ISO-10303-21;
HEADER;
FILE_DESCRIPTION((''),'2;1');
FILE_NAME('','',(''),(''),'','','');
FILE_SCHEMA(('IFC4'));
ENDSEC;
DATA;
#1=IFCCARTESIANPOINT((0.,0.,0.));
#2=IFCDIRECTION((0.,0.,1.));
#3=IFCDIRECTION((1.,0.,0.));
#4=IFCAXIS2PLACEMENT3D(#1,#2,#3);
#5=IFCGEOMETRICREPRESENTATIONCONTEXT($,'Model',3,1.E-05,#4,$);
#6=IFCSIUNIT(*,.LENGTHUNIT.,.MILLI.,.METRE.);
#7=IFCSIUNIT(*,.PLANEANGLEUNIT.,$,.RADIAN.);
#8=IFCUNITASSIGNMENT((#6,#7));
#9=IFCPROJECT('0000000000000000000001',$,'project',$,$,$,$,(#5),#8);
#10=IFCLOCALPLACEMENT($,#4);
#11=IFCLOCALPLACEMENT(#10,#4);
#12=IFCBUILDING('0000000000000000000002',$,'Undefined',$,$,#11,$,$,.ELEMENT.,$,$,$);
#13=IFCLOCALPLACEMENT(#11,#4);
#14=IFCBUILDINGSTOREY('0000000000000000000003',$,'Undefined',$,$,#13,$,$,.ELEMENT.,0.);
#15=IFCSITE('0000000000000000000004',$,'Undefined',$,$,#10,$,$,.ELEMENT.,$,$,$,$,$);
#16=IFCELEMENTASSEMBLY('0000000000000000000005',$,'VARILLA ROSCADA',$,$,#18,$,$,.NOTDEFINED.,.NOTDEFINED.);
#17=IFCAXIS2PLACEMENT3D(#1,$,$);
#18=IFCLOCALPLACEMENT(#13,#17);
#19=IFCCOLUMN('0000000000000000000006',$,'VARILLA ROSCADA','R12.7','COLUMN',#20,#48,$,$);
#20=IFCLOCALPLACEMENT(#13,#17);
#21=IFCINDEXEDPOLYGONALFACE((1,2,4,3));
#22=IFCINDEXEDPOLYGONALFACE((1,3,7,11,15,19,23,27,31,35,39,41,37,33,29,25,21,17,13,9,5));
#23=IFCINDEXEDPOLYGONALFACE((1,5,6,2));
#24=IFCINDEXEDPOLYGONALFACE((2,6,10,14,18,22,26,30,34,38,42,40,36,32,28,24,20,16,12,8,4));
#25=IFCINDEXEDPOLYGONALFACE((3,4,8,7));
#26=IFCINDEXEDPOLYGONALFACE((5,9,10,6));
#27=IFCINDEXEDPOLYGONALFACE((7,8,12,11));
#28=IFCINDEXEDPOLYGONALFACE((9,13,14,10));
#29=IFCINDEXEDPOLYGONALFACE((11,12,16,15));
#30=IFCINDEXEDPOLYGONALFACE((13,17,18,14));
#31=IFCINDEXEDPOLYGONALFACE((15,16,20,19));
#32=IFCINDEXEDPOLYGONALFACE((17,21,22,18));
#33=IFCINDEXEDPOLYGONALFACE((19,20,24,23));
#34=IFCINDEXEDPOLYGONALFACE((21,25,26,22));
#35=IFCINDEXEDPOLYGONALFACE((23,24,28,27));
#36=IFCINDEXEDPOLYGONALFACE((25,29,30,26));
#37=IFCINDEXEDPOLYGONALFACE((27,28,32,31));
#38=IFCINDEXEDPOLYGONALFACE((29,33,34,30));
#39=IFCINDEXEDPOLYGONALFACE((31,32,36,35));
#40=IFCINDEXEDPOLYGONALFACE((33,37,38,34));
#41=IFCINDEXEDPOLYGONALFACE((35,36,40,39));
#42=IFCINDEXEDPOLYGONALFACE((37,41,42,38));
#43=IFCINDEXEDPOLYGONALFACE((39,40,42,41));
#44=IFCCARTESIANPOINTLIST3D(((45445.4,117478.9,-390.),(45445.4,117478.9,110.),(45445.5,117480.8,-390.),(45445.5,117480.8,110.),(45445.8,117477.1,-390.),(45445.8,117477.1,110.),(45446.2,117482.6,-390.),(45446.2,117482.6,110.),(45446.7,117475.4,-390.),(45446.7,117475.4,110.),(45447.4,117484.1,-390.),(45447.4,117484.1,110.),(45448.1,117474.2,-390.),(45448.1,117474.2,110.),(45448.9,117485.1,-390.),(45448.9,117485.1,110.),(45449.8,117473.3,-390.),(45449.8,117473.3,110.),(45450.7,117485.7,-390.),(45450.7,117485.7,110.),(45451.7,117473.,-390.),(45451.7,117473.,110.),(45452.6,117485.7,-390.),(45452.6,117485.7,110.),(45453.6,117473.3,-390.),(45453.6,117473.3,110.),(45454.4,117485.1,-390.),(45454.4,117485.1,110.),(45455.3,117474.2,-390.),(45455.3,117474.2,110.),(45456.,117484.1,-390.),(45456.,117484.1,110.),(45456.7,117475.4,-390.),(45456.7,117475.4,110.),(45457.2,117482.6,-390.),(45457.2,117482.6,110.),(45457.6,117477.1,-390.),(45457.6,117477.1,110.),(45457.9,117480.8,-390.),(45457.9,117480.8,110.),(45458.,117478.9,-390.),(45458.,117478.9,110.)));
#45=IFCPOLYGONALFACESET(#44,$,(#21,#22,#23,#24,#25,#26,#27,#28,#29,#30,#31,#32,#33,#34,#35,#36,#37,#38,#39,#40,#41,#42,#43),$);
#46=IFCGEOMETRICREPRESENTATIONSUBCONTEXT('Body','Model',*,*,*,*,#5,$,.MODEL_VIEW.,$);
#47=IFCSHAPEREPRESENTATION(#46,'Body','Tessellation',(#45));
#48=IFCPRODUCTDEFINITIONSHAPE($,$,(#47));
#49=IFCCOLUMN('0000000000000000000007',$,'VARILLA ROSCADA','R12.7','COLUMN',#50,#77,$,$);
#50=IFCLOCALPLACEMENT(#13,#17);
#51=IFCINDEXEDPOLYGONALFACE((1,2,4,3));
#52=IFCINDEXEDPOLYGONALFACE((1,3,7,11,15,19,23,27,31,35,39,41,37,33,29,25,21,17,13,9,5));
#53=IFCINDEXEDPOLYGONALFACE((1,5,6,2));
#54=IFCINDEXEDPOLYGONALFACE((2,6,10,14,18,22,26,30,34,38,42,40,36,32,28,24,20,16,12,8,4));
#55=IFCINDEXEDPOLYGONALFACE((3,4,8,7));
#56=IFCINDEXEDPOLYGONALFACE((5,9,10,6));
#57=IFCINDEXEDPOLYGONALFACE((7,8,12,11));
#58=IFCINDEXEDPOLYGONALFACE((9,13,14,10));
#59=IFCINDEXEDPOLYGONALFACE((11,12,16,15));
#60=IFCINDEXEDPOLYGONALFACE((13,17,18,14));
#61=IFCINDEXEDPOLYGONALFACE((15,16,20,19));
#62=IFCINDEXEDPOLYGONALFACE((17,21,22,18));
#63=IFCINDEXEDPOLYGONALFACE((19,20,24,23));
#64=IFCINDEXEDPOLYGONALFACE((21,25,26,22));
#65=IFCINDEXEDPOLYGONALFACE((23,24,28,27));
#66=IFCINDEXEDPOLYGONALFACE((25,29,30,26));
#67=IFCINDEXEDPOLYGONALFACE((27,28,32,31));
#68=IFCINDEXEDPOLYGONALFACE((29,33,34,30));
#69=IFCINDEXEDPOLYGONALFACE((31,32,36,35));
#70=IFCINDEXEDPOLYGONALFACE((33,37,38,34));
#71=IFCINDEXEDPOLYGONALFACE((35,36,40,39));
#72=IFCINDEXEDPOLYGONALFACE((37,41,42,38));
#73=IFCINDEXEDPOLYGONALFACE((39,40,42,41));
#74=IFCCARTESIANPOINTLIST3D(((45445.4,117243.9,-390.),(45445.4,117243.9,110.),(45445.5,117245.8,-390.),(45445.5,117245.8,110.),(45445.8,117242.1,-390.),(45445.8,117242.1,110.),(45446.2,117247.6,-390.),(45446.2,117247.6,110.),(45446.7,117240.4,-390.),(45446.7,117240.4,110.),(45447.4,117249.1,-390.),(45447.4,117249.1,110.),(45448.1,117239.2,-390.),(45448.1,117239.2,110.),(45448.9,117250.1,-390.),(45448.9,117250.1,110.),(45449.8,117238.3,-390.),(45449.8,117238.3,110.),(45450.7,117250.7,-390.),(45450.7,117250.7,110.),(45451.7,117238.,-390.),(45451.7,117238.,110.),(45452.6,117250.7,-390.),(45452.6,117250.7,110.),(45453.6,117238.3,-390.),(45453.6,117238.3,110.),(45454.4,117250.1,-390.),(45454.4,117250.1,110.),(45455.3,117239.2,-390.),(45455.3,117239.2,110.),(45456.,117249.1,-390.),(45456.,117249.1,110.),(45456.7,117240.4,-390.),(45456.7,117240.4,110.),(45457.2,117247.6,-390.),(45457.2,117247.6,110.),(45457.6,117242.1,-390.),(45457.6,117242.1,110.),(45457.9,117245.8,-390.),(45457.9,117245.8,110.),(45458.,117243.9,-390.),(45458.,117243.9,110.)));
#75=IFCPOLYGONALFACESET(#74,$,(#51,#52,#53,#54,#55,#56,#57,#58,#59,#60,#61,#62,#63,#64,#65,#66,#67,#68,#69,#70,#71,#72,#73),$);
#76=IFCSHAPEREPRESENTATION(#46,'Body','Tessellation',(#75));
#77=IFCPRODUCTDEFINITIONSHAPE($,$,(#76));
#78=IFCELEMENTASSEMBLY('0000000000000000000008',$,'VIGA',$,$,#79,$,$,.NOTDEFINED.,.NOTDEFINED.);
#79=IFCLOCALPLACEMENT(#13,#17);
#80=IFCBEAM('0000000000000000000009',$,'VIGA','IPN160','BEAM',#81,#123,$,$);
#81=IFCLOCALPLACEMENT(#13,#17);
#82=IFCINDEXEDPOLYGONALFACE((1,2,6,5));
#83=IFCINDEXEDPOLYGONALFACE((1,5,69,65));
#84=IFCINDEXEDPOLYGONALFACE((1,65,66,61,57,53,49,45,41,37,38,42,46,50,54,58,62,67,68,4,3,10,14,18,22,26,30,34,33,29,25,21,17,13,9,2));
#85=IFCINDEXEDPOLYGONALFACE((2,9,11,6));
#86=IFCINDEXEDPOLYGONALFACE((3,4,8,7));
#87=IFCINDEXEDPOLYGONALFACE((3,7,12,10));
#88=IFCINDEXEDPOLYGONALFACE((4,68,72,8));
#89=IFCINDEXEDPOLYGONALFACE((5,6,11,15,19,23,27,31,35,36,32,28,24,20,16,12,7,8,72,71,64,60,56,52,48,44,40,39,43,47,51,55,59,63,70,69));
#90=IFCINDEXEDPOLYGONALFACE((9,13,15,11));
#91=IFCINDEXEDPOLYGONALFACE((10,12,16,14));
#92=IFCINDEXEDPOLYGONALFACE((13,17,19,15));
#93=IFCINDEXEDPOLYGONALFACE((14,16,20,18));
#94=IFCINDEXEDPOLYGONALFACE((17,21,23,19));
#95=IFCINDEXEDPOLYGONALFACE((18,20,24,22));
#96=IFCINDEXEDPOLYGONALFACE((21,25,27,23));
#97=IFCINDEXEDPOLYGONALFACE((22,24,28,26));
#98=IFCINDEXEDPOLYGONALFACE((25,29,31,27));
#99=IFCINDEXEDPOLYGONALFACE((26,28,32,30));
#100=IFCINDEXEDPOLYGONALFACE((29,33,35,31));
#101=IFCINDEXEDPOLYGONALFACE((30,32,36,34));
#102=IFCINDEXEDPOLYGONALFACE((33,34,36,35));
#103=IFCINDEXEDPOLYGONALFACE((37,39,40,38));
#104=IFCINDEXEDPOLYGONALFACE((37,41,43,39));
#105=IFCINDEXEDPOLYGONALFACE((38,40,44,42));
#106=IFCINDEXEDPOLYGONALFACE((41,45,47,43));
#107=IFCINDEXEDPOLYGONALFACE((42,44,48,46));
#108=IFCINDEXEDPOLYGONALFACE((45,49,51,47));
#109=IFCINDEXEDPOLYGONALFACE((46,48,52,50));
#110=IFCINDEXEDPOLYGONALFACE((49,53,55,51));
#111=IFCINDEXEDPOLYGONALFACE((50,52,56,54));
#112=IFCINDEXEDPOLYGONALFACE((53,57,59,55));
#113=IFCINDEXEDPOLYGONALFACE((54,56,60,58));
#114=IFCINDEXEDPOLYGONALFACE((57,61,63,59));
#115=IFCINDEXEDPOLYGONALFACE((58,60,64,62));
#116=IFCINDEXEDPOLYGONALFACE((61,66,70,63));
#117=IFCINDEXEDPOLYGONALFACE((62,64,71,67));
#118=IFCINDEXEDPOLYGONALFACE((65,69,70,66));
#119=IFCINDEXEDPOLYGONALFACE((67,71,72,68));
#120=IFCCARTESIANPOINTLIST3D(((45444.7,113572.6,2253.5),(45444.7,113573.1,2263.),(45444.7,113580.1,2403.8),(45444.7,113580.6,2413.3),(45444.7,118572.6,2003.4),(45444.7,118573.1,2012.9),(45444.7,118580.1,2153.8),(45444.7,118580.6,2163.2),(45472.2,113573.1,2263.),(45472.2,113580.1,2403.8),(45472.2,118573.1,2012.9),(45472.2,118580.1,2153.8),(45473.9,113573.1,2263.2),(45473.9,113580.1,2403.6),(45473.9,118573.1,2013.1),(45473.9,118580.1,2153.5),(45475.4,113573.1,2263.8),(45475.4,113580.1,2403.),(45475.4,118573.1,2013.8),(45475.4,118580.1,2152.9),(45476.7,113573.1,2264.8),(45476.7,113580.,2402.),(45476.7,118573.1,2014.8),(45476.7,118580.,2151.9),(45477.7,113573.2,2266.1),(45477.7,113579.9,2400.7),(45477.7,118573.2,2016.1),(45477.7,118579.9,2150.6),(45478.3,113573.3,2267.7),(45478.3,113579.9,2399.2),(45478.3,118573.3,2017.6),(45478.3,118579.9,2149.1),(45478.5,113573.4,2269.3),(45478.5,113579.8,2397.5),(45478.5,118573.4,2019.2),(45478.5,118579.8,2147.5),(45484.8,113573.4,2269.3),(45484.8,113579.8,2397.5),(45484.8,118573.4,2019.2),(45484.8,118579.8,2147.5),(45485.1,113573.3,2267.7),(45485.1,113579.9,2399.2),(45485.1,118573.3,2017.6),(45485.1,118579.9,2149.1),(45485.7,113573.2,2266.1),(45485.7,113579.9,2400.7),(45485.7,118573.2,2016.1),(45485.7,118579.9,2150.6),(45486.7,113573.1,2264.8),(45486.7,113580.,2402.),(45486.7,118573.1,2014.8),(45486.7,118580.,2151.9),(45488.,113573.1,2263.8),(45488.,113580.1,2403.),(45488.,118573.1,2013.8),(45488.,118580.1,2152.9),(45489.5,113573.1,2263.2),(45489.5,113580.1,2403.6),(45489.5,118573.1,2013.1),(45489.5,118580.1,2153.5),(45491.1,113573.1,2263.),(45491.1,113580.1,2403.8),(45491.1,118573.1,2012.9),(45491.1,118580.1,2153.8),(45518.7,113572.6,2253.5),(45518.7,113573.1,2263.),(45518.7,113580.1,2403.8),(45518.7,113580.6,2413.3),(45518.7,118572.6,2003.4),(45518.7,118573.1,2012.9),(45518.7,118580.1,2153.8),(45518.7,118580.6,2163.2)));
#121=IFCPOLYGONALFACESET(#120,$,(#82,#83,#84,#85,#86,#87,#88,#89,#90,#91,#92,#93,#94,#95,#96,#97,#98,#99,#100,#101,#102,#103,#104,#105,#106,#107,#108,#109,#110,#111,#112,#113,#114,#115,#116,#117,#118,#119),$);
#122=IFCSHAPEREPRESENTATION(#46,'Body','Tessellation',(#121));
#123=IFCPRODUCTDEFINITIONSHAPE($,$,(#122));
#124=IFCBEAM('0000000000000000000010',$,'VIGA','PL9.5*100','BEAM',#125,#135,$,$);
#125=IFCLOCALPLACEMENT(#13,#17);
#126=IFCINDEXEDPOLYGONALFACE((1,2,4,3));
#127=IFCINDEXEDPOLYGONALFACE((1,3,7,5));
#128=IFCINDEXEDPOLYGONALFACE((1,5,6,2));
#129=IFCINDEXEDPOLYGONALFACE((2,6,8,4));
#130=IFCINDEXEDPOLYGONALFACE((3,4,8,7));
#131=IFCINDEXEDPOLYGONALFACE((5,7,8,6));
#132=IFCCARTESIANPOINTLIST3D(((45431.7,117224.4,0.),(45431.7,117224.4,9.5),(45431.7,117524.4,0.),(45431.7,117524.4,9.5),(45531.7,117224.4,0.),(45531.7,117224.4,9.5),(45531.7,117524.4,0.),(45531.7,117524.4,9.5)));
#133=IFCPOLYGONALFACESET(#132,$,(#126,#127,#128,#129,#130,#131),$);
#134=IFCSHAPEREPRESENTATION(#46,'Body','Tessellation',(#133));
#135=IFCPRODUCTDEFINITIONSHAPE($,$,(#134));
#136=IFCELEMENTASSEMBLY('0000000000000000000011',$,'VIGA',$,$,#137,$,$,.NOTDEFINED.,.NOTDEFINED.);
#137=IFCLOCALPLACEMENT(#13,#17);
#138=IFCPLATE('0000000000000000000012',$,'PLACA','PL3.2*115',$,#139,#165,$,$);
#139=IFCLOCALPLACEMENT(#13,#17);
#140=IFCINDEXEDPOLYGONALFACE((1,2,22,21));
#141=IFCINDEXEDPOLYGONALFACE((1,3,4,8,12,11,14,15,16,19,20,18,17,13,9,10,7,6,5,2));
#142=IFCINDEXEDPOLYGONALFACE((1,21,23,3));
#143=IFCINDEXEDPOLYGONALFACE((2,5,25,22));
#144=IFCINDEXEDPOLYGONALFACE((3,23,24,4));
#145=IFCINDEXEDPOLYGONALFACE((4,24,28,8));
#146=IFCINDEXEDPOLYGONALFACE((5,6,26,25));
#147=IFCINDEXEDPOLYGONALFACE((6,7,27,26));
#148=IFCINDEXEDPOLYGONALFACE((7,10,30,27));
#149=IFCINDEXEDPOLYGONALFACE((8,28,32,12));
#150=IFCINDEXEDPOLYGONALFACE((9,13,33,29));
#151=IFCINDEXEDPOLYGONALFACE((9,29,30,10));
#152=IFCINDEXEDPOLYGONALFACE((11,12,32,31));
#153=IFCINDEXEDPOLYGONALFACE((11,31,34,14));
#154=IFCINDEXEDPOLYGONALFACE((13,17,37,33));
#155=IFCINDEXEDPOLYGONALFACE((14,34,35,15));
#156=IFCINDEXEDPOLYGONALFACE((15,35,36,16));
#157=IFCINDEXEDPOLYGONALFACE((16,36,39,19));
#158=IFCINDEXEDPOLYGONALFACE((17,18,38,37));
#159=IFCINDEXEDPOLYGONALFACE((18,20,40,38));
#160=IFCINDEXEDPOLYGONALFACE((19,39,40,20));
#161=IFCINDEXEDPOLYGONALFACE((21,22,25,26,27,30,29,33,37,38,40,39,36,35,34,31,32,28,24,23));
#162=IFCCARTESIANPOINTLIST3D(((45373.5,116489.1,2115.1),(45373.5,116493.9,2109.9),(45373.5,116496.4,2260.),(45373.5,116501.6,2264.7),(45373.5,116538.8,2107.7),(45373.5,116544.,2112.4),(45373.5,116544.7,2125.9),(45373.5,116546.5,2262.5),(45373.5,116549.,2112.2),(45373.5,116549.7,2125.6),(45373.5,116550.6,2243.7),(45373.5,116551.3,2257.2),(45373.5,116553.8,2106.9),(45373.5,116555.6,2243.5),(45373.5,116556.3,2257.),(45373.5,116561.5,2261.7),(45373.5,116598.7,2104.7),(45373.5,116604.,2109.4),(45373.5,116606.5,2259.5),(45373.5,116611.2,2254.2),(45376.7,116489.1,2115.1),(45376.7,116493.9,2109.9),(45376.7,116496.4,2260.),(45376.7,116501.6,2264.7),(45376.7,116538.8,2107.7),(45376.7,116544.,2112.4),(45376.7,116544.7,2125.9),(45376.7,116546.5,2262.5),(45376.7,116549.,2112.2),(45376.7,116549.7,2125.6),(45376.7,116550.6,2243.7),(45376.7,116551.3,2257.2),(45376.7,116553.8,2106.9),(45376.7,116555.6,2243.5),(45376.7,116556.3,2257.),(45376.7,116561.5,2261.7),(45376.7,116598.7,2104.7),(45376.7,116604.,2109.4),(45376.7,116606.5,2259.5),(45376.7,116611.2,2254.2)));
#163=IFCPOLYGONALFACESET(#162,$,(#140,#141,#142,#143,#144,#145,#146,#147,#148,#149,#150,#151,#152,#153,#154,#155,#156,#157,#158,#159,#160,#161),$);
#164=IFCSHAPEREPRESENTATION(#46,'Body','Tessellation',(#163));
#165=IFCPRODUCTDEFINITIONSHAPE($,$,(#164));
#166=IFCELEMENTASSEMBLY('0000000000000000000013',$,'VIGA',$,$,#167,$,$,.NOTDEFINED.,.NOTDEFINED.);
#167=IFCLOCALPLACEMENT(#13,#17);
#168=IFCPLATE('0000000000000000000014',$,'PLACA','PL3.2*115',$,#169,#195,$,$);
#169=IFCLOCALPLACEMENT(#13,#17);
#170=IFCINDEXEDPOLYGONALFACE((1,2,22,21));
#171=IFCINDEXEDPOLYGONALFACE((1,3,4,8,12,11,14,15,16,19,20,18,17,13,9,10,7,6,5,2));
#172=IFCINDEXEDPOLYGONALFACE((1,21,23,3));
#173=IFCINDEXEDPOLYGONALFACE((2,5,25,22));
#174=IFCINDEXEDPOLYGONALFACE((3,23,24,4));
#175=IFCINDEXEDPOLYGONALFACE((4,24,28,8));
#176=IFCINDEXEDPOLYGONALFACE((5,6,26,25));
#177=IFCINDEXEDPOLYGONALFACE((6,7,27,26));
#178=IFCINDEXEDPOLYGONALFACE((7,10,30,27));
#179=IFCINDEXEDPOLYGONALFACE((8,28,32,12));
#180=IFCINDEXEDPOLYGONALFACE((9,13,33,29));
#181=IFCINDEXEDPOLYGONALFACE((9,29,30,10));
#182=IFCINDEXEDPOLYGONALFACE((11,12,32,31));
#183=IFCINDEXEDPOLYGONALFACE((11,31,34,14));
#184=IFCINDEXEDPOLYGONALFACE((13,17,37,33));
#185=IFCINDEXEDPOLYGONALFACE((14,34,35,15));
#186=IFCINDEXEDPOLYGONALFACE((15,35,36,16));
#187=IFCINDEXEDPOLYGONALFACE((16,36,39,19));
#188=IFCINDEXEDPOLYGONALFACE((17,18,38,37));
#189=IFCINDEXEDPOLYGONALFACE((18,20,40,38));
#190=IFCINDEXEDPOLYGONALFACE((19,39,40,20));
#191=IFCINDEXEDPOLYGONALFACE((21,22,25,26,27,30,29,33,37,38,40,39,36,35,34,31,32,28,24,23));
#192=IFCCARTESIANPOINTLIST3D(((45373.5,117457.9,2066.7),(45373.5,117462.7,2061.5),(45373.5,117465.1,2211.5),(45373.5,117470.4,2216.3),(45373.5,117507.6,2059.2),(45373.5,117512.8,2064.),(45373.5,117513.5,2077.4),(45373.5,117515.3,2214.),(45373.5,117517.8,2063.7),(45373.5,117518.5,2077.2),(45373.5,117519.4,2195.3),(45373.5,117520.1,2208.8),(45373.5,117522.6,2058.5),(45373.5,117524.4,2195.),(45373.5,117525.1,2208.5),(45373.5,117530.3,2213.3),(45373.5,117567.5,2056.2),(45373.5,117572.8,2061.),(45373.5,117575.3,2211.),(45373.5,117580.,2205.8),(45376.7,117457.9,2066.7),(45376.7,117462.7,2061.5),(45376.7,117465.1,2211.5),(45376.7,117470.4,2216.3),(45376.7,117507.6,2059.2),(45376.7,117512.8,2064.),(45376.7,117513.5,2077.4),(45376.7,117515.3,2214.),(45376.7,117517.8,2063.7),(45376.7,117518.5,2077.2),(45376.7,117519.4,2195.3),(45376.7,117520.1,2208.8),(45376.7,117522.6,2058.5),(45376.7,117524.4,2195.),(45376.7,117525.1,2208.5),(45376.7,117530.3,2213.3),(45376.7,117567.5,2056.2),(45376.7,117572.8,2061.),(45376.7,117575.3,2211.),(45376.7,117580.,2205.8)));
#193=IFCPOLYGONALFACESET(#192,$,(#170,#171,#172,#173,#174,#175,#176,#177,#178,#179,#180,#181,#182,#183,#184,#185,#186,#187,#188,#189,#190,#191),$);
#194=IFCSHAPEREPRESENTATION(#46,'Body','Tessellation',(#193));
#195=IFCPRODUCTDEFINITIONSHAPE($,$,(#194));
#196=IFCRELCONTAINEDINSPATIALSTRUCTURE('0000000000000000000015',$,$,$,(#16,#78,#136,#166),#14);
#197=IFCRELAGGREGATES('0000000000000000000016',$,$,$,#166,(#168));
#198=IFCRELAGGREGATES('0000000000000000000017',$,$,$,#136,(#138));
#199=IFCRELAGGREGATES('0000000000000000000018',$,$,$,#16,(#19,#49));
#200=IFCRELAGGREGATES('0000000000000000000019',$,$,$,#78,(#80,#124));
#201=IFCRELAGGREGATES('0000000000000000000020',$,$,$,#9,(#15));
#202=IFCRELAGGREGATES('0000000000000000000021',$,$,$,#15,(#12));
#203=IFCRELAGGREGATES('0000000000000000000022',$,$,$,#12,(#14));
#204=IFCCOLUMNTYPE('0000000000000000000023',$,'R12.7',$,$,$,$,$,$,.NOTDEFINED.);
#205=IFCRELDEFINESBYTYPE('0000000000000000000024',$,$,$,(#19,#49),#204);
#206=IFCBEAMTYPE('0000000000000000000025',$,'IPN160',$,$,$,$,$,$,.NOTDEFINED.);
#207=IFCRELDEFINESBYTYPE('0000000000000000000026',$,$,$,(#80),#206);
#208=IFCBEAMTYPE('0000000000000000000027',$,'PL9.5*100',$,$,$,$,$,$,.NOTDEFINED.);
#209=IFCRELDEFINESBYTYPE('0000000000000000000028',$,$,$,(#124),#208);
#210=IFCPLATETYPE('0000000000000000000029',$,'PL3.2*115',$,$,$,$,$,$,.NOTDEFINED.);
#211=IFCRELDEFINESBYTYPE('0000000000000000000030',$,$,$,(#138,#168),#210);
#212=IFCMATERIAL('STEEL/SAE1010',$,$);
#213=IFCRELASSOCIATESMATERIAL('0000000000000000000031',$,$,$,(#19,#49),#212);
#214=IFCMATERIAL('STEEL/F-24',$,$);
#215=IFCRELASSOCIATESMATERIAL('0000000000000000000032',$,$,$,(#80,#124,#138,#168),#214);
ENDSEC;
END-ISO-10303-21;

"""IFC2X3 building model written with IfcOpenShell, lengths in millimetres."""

from ifc_helpers import new_model, si_unit, frame, origin_with_axes, origin_2d_with_axis, place, context, subcontext, project, spatial, polyline, rectangle, circle, i_section, outline, extrude, material, type_object, element, aggregate, save


model = new_model("IFC2X3")

# Units and contexts
model_context = context("Model", 3, precision=1e-05, world=origin_with_axes())
body_context = subcontext(model_context, "Body", "Model", "MODEL_VIEW")
ifc_project = project(units=[si_unit("LENGTHUNIT", "METRE", prefix="MILLI"), si_unit("PLANEANGLEUNIT", "RADIAN")], contexts=[model_context])

# Site, building, storey
site_placement = place(None, origin_with_axes())
site = spatial("IfcSite", under=ifc_project, at=site_placement, Name="Undefined", CompositionType="ELEMENT")
building_placement = place(site_placement, origin_with_axes())
building = spatial("IfcBuilding", under=site, at=building_placement, Name="Undefined", CompositionType="ELEMENT")
storey_placement = place(building_placement, origin_with_axes())
storey = spatial("IfcBuildingStorey", under=building, at=storey_placement, Name="Undefined", CompositionType="ELEMENT", Elevation=0.0)

# Element assembly, columns
assembly_1_placement = place(storey_placement, origin_with_axes())
assembly_1 = element("IfcElementAssembly", 1, at=assembly_1_placement, inside=storey, Name="VARILLA ROSCADA", AssemblyPlace="NOTDEFINED", PredefinedType="NOTDEFINED")
ifc_material_1 = material(Name="STEEL/SAE1010")
column_type = type_object("IfcColumnType", Name="R12.7", PredefinedType="NOTDEFINED")
column_1_placement = place(assembly_1_placement, frame((45451.7, 117479.4, -390.0), z_axis=(0.0, 0.0, 1.0), x_axis=(-1.0, 0.0, 0.0)))
column_1 = element("IfcColumn", 2, at=column_1_placement, type_object=column_type, material=ifc_material_1, Name="VARILLA ROSCADA", Description="R12.7", ObjectType="COLUMN", context=body_context, shape_type="SweptSolid", body=[
    extrude(circle(Radius=6.3, at=origin_2d_with_axis()), frame((0.0, 0.0, 500.0), z_axis=(0.0, 0.0, -1.0), x_axis=(0.0, 1.0, 0.0)), (0.0, 0.0, 1.0), 500.0),
])
column_2_placement = place(assembly_1_placement, frame((45451.7, 117244.4, -390.0), z_axis=(0.0, 0.0, 1.0), x_axis=(-1.0, 0.0, 0.0)))
column_2 = element("IfcColumn", 3, at=column_2_placement, type_object=column_type, material=ifc_material_1, Name="VARILLA ROSCADA", Description="R12.7", ObjectType="COLUMN", context=body_context, shape_type="SweptSolid", body=[
    extrude(circle(Radius=6.3, at=origin_2d_with_axis()), frame((0.0, 0.0, 500.0), z_axis=(0.0, 0.0, -1.0), x_axis=(0.0, 1.0, 0.0)), (0.0, 0.0, 1.0), 500.0),
])

# Element assembly, beams
assembly_2_placement = place(storey_placement, origin_with_axes())
assembly_2 = element("IfcElementAssembly", 4, at=assembly_2_placement, inside=storey, Name="VIGA", AssemblyPlace="NOTDEFINED", PredefinedType="NOTDEFINED")
ifc_material_2 = material(Name="STEEL/F-24")
beam_type_1 = type_object("IfcBeamType", Name="IPN160", PredefinedType="NOTDEFINED")
beam_1_placement = place(assembly_2_placement, frame((45481.7, 118576.6, 2083.3), z_axis=(0.0, 0.04995, 0.998752), x_axis=(0.0, -0.998752, 0.04995)))
beam_1 = element("IfcBeam", 5, at=beam_1_placement, type_object=beam_type_1, material=ifc_material_2, Name="VIGA", Description="IPN160", ObjectType="BEAM", context=body_context, shape_type="SweptSolid", body=[
    extrude(i_section(OverallWidth=74.0, OverallDepth=160.0, WebThickness=6.3, FlangeThickness=9.5, FilletRadius=6.3, at=origin_2d_with_axis()), frame((5006.2, 0.0, 0.0), z_axis=(-1.0, 0.0, 0.0), x_axis=(0.0, -1.0, 0.0)), (0.0, 0.0, 1.0), 5006.2),
])
beam_type_2 = type_object("IfcBeamType", Name="PL9.5*100", PredefinedType="NOTDEFINED")
beam_2_placement = place(assembly_2_placement, frame((45481.7, 117524.4, 4.7), z_axis=(1.0, 0.0, 0.0), x_axis=(0.0, -1.0, 0.0)))
beam_2 = element("IfcBeam", 6, at=beam_2_placement, type_object=beam_type_2, material=ifc_material_2, Name="VIGA", Description="PL9.5*100", ObjectType="BEAM", context=body_context, shape_type="SweptSolid", body=[
    extrude(rectangle(XDim=9.5, YDim=100.0, at=origin_2d_with_axis()), frame((300.0, 0.0, 0.0), z_axis=(-1.0, 0.0, 0.0), x_axis=(0.0, -1.0, 0.0)), (0.0, 0.0, 1.0), 300.0),
])

# Element assemblies, plates
assembly_3_placement = place(storey_placement, origin_with_axes())
assembly_3 = element("IfcElementAssembly", 7, at=assembly_3_placement, inside=storey, Name="VIGA", AssemblyPlace="NOTDEFINED", PredefinedType="NOTDEFINED")
plate_type_1 = type_object("IfcPlateType", Name="PL3.2*115", PredefinedType="NOTDEFINED")
plate_1_placement = place(assembly_3_placement, frame((45375.1, 116611.5, 2259.2), z_axis=(1.0, 0.0, 0.0), x_axis=(0.0, -0.998752, 0.04995)))
plate_1 = element("IfcPlate", 8, at=plate_1_placement, type_object=plate_type_1, material=ifc_material_2, Name="PLACA", Description="PL3.2*115", context=body_context, shape_type="SweptSolid", body=[
    extrude(outline(polyline([(0.0, 5.0), (5.0, 0.0), (50.0, 0.0), (55.0, 5.0), (55.0, 18.5), (60.0, 18.5), (60.0, 5.0), (65.0, 0.0), (110.0, 0.0), (115.0, 5.0), (115.0, 150.0), (110.0, 155.0), (65.0, 155.0), (60.0, 150.0), (60.0, 136.5), (55.0, 136.5), (55.0, 150.0), (50.0, 155.0), (5.0, 155.0), (0.0, 150.0), (0.0, 5.0)])), frame((0.0, 0.0, -1.6), z_axis=(0.0, 0.0, 1.0), x_axis=(1.0, 0.0, 0.0)), (0.0, 0.0, 1.0), 3.2),
])
assembly_4_placement = place(storey_placement, origin_with_axes())
assembly_4 = element("IfcElementAssembly", 9, at=assembly_4_placement, inside=storey, Name="VIGA", AssemblyPlace="NOTDEFINED", PredefinedType="NOTDEFINED")
plate_2_placement = place(assembly_4_placement, frame((45375.1, 117580.3, 2210.8), z_axis=(1.0, 0.0, 0.0), x_axis=(0.0, -0.998752, 0.04995)))
plate_2 = element("IfcPlate", 10, at=plate_2_placement, type_object=plate_type_1, material=ifc_material_2, Name="PLACA", Description="PL3.2*115", context=body_context, shape_type="SweptSolid", body=[
    extrude(outline(polyline([(0.0, 5.0), (5.0, 0.0), (50.0, 0.0), (55.0, 5.0), (55.0, 18.5), (60.0, 18.5), (60.0, 5.0), (65.0, 0.0), (110.0, 0.0), (115.0, 5.0), (115.0, 150.0), (110.0, 155.0), (65.0, 155.0), (60.0, 150.0), (60.0, 136.5), (55.0, 136.5), (55.0, 150.0), (50.0, 155.0), (5.0, 155.0), (0.0, 150.0), (0.0, 5.0)])), frame((0.0, 0.0, -1.6), z_axis=(0.0, 0.0, 1.0), x_axis=(1.0, 0.0, 0.0)), (0.0, 0.0, 1.0), 3.2),
])

aggregate(assembly_4, [plate_2])
aggregate(assembly_3, [plate_1])

aggregate(assembly_1, [column_1, column_2])

aggregate(assembly_2, [beam_1, beam_2])

save(model, "model.ifc")
